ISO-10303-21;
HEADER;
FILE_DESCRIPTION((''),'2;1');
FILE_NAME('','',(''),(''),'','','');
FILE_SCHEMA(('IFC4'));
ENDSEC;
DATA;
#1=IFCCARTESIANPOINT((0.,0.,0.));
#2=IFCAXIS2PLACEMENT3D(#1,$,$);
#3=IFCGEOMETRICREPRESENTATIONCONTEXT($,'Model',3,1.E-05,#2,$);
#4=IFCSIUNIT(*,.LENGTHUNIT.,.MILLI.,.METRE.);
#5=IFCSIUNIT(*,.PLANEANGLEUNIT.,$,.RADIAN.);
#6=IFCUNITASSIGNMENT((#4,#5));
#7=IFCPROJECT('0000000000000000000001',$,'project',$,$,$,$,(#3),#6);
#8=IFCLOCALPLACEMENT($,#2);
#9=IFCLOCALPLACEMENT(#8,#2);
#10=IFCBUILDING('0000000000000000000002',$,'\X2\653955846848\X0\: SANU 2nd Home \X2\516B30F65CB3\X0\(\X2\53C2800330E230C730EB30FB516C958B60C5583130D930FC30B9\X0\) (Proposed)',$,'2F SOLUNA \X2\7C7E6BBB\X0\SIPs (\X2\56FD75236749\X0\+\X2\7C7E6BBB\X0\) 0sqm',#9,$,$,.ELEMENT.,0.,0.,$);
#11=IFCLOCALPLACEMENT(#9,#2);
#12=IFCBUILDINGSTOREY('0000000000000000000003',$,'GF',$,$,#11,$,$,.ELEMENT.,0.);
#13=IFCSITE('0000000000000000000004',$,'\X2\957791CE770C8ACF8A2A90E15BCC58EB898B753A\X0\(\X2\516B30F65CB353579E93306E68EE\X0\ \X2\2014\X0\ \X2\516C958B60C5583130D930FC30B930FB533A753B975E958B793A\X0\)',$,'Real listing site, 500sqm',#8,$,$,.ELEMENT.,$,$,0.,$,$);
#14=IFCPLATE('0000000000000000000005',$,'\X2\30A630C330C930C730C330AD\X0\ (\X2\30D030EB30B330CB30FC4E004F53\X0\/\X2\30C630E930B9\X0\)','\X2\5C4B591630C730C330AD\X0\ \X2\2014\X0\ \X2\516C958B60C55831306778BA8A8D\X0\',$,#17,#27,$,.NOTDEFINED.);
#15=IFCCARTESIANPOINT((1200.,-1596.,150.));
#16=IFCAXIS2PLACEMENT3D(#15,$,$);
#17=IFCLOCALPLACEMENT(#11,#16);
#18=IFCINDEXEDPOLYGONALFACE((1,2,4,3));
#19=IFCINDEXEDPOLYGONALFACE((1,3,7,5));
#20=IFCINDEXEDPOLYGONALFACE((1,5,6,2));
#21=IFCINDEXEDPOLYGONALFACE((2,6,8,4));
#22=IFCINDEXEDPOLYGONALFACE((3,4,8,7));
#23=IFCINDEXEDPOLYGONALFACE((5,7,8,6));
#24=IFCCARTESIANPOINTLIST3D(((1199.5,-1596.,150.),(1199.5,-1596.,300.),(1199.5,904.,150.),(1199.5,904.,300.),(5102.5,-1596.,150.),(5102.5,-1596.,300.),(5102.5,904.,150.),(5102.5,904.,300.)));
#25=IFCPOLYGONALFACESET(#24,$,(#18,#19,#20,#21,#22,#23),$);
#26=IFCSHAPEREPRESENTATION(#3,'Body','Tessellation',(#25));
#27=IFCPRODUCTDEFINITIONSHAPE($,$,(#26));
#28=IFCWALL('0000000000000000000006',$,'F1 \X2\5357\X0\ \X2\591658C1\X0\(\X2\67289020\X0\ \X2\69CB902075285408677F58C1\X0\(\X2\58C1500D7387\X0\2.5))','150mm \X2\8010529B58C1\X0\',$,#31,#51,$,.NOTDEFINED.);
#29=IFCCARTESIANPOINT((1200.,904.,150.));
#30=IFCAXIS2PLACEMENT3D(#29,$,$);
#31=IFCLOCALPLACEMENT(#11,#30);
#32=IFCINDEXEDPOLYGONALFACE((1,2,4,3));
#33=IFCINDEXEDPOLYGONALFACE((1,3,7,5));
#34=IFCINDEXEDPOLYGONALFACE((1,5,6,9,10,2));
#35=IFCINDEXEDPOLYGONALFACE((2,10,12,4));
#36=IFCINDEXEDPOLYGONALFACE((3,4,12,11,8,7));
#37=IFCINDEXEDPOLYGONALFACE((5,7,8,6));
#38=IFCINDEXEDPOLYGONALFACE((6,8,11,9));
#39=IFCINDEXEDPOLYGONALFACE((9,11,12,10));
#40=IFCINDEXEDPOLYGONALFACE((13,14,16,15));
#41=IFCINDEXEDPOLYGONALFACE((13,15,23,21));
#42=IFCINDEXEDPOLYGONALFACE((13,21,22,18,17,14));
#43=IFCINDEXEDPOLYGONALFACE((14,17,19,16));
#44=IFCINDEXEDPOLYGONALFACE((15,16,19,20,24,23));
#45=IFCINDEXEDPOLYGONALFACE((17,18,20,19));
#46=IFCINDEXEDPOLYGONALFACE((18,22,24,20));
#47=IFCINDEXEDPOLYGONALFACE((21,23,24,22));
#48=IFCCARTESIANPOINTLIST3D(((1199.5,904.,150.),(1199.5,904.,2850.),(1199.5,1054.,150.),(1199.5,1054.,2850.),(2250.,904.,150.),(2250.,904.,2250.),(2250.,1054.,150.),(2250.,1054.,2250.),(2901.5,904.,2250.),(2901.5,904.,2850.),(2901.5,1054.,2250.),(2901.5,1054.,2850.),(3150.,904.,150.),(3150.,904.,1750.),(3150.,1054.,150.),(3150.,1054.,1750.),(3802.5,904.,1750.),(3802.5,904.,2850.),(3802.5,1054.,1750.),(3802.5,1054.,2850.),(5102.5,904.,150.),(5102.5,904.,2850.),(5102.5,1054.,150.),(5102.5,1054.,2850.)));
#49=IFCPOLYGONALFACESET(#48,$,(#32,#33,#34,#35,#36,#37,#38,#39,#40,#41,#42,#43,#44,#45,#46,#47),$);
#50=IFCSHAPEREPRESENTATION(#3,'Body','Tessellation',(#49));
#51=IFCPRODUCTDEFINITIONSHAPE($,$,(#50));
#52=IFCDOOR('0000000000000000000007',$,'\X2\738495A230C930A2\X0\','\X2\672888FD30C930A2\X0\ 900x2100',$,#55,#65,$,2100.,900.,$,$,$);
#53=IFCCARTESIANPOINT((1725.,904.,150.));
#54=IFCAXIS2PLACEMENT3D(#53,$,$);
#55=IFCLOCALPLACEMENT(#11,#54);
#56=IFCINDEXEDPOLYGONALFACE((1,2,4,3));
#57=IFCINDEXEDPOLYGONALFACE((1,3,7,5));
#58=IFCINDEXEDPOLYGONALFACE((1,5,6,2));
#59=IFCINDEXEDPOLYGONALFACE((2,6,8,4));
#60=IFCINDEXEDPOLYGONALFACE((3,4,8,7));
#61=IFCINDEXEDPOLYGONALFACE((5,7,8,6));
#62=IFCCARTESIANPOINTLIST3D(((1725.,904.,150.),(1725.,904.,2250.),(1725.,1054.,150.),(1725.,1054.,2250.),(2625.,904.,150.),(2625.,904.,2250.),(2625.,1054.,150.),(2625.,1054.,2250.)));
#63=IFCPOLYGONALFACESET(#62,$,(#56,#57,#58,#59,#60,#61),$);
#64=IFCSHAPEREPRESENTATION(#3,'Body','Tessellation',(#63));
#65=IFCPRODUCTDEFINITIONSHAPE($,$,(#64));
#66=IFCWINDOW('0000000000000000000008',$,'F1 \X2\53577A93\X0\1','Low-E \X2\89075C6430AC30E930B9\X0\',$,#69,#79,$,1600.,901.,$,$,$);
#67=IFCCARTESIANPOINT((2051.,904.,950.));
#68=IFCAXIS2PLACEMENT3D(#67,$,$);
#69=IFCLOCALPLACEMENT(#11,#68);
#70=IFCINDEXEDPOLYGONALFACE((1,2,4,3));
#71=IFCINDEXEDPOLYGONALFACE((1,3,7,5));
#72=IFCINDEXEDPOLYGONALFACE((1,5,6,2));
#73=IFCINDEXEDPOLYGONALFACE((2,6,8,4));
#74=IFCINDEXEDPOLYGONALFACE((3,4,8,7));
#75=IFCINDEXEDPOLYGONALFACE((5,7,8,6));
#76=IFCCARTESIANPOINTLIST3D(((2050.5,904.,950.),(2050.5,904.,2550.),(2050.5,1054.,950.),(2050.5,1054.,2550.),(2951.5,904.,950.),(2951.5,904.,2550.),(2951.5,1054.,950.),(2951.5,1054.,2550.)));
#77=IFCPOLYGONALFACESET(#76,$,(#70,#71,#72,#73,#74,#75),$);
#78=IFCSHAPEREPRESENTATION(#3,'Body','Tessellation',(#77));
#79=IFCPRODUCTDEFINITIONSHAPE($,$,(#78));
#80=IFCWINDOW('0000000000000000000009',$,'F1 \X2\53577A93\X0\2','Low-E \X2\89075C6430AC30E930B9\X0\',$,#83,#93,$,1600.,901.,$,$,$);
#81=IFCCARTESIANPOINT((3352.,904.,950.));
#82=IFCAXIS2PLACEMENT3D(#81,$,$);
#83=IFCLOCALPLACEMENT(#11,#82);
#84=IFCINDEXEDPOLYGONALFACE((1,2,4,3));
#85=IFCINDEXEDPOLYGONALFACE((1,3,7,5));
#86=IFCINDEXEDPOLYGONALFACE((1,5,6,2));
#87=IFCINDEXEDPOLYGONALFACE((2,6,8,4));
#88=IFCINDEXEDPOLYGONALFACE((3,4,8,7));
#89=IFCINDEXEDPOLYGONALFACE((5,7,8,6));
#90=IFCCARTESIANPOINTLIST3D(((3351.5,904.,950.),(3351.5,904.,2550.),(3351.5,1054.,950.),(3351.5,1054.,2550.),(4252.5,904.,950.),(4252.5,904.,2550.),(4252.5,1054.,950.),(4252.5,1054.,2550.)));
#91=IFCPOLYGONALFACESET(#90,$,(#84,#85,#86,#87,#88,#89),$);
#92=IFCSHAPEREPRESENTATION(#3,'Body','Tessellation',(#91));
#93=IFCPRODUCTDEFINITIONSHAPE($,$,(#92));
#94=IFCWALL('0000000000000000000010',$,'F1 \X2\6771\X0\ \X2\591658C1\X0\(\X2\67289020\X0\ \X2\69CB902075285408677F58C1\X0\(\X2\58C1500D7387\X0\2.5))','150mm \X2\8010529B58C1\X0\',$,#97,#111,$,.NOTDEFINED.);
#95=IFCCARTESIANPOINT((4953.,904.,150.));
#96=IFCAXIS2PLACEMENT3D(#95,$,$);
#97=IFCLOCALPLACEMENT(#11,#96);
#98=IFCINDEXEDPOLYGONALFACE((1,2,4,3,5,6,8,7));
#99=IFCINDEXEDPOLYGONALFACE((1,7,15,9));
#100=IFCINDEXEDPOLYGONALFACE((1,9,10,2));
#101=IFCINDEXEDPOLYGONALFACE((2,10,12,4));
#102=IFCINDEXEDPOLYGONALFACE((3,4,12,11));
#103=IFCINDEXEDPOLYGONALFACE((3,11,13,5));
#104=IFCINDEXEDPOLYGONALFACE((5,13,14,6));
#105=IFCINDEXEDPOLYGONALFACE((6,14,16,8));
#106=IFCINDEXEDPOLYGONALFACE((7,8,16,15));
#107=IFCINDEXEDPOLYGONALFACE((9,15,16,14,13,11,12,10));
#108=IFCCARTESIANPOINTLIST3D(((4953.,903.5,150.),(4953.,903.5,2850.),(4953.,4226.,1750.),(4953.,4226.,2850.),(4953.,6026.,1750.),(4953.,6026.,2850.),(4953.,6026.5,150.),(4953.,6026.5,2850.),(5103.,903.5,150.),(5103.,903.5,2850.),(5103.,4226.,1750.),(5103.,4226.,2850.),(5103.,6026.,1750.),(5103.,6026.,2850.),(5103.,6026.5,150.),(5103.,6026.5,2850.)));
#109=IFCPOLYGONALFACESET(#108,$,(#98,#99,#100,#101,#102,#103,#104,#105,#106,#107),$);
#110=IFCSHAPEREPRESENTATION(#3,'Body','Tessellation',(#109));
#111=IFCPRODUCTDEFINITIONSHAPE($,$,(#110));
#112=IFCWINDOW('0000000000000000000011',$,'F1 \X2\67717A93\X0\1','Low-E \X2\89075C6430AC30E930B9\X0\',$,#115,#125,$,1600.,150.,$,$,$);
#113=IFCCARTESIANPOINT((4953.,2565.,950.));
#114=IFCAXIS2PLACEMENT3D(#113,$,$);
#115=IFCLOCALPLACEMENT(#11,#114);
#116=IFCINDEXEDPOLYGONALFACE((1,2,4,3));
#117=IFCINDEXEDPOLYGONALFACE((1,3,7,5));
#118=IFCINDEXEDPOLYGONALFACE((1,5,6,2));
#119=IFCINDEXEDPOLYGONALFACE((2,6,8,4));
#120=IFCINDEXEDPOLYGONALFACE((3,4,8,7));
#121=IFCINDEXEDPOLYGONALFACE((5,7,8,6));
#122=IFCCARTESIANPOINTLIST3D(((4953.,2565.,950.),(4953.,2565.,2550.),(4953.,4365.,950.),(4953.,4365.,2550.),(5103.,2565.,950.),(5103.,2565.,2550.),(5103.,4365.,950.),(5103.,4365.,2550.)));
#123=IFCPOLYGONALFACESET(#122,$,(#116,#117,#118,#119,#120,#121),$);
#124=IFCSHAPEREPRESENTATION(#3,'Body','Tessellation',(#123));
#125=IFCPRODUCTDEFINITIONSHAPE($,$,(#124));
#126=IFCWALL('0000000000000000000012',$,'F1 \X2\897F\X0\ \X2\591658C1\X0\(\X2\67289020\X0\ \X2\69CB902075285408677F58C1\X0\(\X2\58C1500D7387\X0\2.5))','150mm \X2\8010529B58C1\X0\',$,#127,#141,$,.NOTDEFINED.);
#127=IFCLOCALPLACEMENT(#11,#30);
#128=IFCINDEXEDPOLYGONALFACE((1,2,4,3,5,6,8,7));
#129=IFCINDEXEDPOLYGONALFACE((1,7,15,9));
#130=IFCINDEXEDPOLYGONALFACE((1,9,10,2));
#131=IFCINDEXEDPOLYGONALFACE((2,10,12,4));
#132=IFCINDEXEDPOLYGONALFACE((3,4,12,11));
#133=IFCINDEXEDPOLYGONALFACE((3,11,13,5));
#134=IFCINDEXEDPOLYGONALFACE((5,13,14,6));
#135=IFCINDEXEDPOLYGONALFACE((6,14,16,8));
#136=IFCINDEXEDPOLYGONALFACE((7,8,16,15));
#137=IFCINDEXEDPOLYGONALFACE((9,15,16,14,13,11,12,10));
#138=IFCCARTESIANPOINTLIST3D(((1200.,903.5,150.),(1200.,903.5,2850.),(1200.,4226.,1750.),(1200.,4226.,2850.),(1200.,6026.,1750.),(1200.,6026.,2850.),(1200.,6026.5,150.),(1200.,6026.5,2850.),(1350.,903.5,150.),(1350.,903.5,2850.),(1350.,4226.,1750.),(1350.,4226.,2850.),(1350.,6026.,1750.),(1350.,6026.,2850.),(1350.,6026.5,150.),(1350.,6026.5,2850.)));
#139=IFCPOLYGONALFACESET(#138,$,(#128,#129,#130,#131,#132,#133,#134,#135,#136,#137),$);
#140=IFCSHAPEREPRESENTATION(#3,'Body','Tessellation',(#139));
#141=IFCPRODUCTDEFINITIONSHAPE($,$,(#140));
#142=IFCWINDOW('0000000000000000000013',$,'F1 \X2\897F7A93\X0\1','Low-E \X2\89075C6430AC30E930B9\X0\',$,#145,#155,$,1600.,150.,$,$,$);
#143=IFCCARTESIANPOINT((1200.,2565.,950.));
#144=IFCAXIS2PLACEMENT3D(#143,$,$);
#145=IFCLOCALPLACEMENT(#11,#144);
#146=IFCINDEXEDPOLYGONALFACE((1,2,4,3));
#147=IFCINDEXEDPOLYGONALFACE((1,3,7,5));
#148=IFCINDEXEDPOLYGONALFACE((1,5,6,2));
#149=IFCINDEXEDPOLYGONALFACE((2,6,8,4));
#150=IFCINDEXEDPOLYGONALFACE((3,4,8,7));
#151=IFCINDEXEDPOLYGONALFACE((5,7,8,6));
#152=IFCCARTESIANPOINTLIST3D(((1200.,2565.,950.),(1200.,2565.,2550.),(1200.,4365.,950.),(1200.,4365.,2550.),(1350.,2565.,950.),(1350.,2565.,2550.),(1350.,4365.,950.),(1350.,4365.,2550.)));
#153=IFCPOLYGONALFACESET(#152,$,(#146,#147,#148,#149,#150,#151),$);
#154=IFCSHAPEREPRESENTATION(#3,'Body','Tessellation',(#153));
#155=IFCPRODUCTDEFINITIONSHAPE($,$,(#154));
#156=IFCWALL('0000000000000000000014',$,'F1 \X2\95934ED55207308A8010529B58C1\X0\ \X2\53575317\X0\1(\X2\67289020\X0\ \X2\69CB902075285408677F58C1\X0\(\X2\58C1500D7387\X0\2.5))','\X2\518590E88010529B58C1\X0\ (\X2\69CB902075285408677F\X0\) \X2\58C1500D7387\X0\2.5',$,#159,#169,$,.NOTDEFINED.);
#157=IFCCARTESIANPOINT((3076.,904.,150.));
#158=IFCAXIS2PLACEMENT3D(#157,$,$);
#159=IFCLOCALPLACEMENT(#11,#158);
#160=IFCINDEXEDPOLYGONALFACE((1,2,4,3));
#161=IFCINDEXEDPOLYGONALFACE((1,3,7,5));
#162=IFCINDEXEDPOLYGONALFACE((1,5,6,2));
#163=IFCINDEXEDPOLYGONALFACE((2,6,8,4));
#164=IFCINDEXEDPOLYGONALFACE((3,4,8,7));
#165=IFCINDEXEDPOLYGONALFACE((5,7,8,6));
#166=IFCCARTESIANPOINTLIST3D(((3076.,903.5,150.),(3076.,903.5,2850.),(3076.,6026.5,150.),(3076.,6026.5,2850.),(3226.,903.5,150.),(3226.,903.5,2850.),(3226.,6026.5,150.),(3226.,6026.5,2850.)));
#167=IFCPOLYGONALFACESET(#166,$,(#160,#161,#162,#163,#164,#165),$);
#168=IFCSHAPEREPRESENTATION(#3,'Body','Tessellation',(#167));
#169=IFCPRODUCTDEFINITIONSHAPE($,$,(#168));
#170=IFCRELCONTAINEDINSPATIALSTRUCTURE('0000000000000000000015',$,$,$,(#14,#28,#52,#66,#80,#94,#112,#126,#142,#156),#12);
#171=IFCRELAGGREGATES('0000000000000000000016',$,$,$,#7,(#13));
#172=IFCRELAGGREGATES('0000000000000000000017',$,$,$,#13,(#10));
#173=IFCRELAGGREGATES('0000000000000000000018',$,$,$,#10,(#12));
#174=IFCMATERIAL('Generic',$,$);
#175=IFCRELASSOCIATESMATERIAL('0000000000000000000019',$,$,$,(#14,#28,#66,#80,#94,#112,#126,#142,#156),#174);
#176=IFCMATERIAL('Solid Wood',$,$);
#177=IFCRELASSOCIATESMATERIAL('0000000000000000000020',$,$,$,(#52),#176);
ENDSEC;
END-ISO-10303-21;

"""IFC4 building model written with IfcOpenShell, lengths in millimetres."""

from ifc_helpers import new_model, si_unit, frame, frame_2d, origin, place, context, project, spatial, rectangle, extrude, material, element, fill, save


model = new_model("IFC4")

# Units and contexts
model_context = context("Model", 3, precision=1e-05, world=origin())
ifc_project = project(units=[si_unit("LENGTHUNIT", "METRE", prefix="MILLI"), si_unit("PLANEANGLEUNIT", "RADIAN")], contexts=[model_context])

# Site, building, storey
site_placement = place(None, origin())
site = spatial("IfcSite", under=ifc_project, at=site_placement, Name="長野県諏訪郡富士見町(八ヶ岳南麓の森 — 公開情報ベース・区画非開示)", ObjectType="Real listing site, 500sqm", CompositionType="ELEMENT", RefElevation=0.0)
building_placement = place(site_placement, origin())
building = spatial("IfcBuilding", under=site, at=building_placement, Name="改善案: SANU 2nd Home 八ヶ岳(参考モデル・公開情報ベース) (Proposed)", ObjectType="2F SOLUNA 籾殻SIPs (国産杉+籾殻) 0sqm", CompositionType="ELEMENT", ElevationOfRefHeight=0.0, ElevationOfTerrain=0.0)
storey_placement = place(building_placement, origin())
storey = spatial("IfcBuildingStorey", under=building, at=storey_placement, Name="GF", CompositionType="ELEMENT", Elevation=0.0)

# Shared definitions
ifc_material_1 = material(Name="Generic")

# Plate
plate_placement = place(storey_placement, frame((1200.0, -1596.0, 150.0)))
element("IfcPlate", 1, at=plate_placement, inside=storey, material=ifc_material_1, Name="ウッドデッキ (バルコニー一体/テラス)", Description="屋外デッキ — 公開情報で確認", PredefinedType="NOTDEFINED", context=model_context, shape_type="SweptSolid", body=[
    extrude(rectangle(XDim=3903.0, YDim=2500.0, at=frame_2d((1951.0, 1250.0))), frame((1200.0, -1596.0, 150.0)), (0.0, 0.0, 1.0), 150.0),
])

# Wall, openings, door, windows
wall_1_placement = place(storey_placement, frame((1200.0, 904.0, 150.0)))
wall_1 = element("IfcWall", 2, at=wall_1_placement, inside=storey, material=ifc_material_1, Name="F1 南 外壁(木造 構造用合板壁(壁倍率2.5))", Description="150mm 耐力壁", PredefinedType="NOTDEFINED", context=model_context, shape_type="SweptSolid", body=[
    extrude(rectangle(XDim=3903.0, YDim=150.0, at=frame_2d((1951.0, 75.0))), frame((1200.0, 904.0, 150.0)), (0.0, 0.0, 1.0), 2700.0),
])
opening_1_placement = place(storey_placement, frame((1725.0, 904.0, 150.0)))
opening_1 = element("IfcOpeningElement", 3, at=opening_1_placement, cuts=wall_1, PredefinedType="NOTDEFINED", context=model_context, shape_type="SweptSolid", body=[
    extrude(rectangle(XDim=900.0, YDim=150.0, at=frame_2d((450.0, 75.0))), frame((1725.0, 904.0, 150.0)), (0.0, 0.0, 1.0), 2100.0),
])
opening_2_placement = place(storey_placement, frame((2051.0, 904.0, 950.0)))
opening_2 = element("IfcOpeningElement", 4, at=opening_2_placement, cuts=wall_1, PredefinedType="NOTDEFINED", context=model_context, shape_type="SweptSolid", body=[
    extrude(rectangle(XDim=901.0, YDim=150.0, at=frame_2d((450.0, 75.0))), frame((2051.0, 904.0, 950.0)), (0.0, 0.0, 1.0), 1600.0),
])
opening_3_placement = place(storey_placement, frame((3352.0, 904.0, 950.0)))
opening_3 = element("IfcOpeningElement", 5, at=opening_3_placement, cuts=wall_1, PredefinedType="NOTDEFINED", context=model_context, shape_type="SweptSolid", body=[
    extrude(rectangle(XDim=901.0, YDim=150.0, at=frame_2d((450.0, 75.0))), frame((3352.0, 904.0, 950.0)), (0.0, 0.0, 1.0), 1600.0),
])
ifc_material_2 = material(Name="Solid Wood")
door_placement = place(storey_placement, frame((1725.0, 904.0, 150.0)))
door = element("IfcDoor", 6, at=door_placement, inside=storey, material=ifc_material_2, Name="玄関ドア", Description="木製ドア 900x2100", OverallHeight=2100.0, OverallWidth=900.0, context=model_context, shape_type="SweptSolid", body=[
    extrude(rectangle(XDim=900.0, YDim=150.0, at=frame_2d((450.0, 75.0))), frame((1725.0, 904.0, 150.0)), (0.0, 0.0, 1.0), 2100.0),
])
fill(opening_1, door)
window_1_placement = place(storey_placement, frame((2051.0, 904.0, 950.0)))
window_1 = element("IfcWindow", 7, at=window_1_placement, inside=storey, material=ifc_material_1, Name="F1 南窓1", Description="Low-E 複層ガラス", OverallHeight=1600.0, OverallWidth=901.0, context=model_context, shape_type="SweptSolid", body=[
    extrude(rectangle(XDim=901.0, YDim=150.0, at=frame_2d((450.0, 75.0))), frame((2051.0, 904.0, 950.0)), (0.0, 0.0, 1.0), 1600.0),
])
fill(opening_2, window_1)
window_2_placement = place(storey_placement, frame((3352.0, 904.0, 950.0)))
window_2 = element("IfcWindow", 8, at=window_2_placement, inside=storey, material=ifc_material_1, Name="F1 南窓2", Description="Low-E 複層ガラス", OverallHeight=1600.0, OverallWidth=901.0, context=model_context, shape_type="SweptSolid", body=[
    extrude(rectangle(XDim=901.0, YDim=150.0, at=frame_2d((450.0, 75.0))), frame((3352.0, 904.0, 950.0)), (0.0, 0.0, 1.0), 1600.0),
])
fill(opening_3, window_2)

# Walls, openings, windows
wall_2_placement = place(storey_placement, frame((4953.0, 904.0, 150.0)))
wall_2 = element("IfcWall", 9, at=wall_2_placement, inside=storey, material=ifc_material_1, Name="F1 東 外壁(木造 構造用合板壁(壁倍率2.5))", Description="150mm 耐力壁", PredefinedType="NOTDEFINED", context=model_context, shape_type="SweptSolid", body=[
    extrude(rectangle(XDim=150.0, YDim=5123.0, at=frame_2d((75.0, 2561.0))), frame((4953.0, 904.0, 150.0)), (0.0, 0.0, 1.0), 2700.0),
])
opening_4_placement = place(storey_placement, frame((4953.0, 2565.0, 950.0)))
opening_4 = element("IfcOpeningElement", 10, at=opening_4_placement, cuts=wall_2, PredefinedType="NOTDEFINED", context=model_context, shape_type="SweptSolid", body=[
    extrude(rectangle(XDim=150.0, YDim=1800.0, at=frame_2d((75.0, 900.0))), frame((4953.0, 2565.0, 950.0)), (0.0, 0.0, 1.0), 1600.0),
])
window_3_placement = place(storey_placement, frame((4953.0, 2565.0, 950.0)))
window_3 = element("IfcWindow", 11, at=window_3_placement, inside=storey, material=ifc_material_1, Name="F1 東窓1", Description="Low-E 複層ガラス", OverallHeight=1600.0, OverallWidth=150.0, context=model_context, shape_type="SweptSolid", body=[
    extrude(rectangle(XDim=150.0, YDim=1800.0, at=frame_2d((75.0, 900.0))), frame((4953.0, 2565.0, 950.0)), (0.0, 0.0, 1.0), 1600.0),
])
fill(opening_4, window_3)
wall_3_placement = place(storey_placement, frame((1200.0, 904.0, 150.0)))
wall_3 = element("IfcWall", 12, at=wall_3_placement, inside=storey, material=ifc_material_1, Name="F1 西 外壁(木造 構造用合板壁(壁倍率2.5))", Description="150mm 耐力壁", PredefinedType="NOTDEFINED", context=model_context, shape_type="SweptSolid", body=[
    extrude(rectangle(XDim=150.0, YDim=5123.0, at=frame_2d((75.0, 2561.0))), frame((1200.0, 904.0, 150.0)), (0.0, 0.0, 1.0), 2700.0),
])
opening_5_placement = place(storey_placement, frame((1200.0, 2565.0, 950.0)))
opening_5 = element("IfcOpeningElement", 13, at=opening_5_placement, cuts=wall_3, PredefinedType="NOTDEFINED", context=model_context, shape_type="SweptSolid", body=[
    extrude(rectangle(XDim=150.0, YDim=1800.0, at=frame_2d((75.0, 900.0))), frame((1200.0, 2565.0, 950.0)), (0.0, 0.0, 1.0), 1600.0),
])
window_4_placement = place(storey_placement, frame((1200.0, 2565.0, 950.0)))
window_4 = element("IfcWindow", 14, at=window_4_placement, inside=storey, material=ifc_material_1, Name="F1 西窓1", Description="Low-E 複層ガラス", OverallHeight=1600.0, OverallWidth=150.0, context=model_context, shape_type="SweptSolid", body=[
    extrude(rectangle(XDim=150.0, YDim=1800.0, at=frame_2d((75.0, 900.0))), frame((1200.0, 2565.0, 950.0)), (0.0, 0.0, 1.0), 1600.0),
])
fill(opening_5, window_4)

# Wall
wall_4_placement = place(storey_placement, frame((3076.0, 904.0, 150.0)))
element("IfcWall", 15, at=wall_4_placement, inside=storey, material=ifc_material_1, Name="F1 間仕切り耐力壁 南北1(木造 構造用合板壁(壁倍率2.5))", Description="内部耐力壁 (構造用合板) 壁倍率2.5", PredefinedType="NOTDEFINED", context=model_context, shape_type="SweptSolid", body=[
    extrude(rectangle(XDim=150.0, YDim=5123.0, at=frame_2d((75.0, 2561.0))), frame((3076.0, 904.0, 150.0)), (0.0, 0.0, 1.0), 2700.0),
])

save(model, "model.ifc")
